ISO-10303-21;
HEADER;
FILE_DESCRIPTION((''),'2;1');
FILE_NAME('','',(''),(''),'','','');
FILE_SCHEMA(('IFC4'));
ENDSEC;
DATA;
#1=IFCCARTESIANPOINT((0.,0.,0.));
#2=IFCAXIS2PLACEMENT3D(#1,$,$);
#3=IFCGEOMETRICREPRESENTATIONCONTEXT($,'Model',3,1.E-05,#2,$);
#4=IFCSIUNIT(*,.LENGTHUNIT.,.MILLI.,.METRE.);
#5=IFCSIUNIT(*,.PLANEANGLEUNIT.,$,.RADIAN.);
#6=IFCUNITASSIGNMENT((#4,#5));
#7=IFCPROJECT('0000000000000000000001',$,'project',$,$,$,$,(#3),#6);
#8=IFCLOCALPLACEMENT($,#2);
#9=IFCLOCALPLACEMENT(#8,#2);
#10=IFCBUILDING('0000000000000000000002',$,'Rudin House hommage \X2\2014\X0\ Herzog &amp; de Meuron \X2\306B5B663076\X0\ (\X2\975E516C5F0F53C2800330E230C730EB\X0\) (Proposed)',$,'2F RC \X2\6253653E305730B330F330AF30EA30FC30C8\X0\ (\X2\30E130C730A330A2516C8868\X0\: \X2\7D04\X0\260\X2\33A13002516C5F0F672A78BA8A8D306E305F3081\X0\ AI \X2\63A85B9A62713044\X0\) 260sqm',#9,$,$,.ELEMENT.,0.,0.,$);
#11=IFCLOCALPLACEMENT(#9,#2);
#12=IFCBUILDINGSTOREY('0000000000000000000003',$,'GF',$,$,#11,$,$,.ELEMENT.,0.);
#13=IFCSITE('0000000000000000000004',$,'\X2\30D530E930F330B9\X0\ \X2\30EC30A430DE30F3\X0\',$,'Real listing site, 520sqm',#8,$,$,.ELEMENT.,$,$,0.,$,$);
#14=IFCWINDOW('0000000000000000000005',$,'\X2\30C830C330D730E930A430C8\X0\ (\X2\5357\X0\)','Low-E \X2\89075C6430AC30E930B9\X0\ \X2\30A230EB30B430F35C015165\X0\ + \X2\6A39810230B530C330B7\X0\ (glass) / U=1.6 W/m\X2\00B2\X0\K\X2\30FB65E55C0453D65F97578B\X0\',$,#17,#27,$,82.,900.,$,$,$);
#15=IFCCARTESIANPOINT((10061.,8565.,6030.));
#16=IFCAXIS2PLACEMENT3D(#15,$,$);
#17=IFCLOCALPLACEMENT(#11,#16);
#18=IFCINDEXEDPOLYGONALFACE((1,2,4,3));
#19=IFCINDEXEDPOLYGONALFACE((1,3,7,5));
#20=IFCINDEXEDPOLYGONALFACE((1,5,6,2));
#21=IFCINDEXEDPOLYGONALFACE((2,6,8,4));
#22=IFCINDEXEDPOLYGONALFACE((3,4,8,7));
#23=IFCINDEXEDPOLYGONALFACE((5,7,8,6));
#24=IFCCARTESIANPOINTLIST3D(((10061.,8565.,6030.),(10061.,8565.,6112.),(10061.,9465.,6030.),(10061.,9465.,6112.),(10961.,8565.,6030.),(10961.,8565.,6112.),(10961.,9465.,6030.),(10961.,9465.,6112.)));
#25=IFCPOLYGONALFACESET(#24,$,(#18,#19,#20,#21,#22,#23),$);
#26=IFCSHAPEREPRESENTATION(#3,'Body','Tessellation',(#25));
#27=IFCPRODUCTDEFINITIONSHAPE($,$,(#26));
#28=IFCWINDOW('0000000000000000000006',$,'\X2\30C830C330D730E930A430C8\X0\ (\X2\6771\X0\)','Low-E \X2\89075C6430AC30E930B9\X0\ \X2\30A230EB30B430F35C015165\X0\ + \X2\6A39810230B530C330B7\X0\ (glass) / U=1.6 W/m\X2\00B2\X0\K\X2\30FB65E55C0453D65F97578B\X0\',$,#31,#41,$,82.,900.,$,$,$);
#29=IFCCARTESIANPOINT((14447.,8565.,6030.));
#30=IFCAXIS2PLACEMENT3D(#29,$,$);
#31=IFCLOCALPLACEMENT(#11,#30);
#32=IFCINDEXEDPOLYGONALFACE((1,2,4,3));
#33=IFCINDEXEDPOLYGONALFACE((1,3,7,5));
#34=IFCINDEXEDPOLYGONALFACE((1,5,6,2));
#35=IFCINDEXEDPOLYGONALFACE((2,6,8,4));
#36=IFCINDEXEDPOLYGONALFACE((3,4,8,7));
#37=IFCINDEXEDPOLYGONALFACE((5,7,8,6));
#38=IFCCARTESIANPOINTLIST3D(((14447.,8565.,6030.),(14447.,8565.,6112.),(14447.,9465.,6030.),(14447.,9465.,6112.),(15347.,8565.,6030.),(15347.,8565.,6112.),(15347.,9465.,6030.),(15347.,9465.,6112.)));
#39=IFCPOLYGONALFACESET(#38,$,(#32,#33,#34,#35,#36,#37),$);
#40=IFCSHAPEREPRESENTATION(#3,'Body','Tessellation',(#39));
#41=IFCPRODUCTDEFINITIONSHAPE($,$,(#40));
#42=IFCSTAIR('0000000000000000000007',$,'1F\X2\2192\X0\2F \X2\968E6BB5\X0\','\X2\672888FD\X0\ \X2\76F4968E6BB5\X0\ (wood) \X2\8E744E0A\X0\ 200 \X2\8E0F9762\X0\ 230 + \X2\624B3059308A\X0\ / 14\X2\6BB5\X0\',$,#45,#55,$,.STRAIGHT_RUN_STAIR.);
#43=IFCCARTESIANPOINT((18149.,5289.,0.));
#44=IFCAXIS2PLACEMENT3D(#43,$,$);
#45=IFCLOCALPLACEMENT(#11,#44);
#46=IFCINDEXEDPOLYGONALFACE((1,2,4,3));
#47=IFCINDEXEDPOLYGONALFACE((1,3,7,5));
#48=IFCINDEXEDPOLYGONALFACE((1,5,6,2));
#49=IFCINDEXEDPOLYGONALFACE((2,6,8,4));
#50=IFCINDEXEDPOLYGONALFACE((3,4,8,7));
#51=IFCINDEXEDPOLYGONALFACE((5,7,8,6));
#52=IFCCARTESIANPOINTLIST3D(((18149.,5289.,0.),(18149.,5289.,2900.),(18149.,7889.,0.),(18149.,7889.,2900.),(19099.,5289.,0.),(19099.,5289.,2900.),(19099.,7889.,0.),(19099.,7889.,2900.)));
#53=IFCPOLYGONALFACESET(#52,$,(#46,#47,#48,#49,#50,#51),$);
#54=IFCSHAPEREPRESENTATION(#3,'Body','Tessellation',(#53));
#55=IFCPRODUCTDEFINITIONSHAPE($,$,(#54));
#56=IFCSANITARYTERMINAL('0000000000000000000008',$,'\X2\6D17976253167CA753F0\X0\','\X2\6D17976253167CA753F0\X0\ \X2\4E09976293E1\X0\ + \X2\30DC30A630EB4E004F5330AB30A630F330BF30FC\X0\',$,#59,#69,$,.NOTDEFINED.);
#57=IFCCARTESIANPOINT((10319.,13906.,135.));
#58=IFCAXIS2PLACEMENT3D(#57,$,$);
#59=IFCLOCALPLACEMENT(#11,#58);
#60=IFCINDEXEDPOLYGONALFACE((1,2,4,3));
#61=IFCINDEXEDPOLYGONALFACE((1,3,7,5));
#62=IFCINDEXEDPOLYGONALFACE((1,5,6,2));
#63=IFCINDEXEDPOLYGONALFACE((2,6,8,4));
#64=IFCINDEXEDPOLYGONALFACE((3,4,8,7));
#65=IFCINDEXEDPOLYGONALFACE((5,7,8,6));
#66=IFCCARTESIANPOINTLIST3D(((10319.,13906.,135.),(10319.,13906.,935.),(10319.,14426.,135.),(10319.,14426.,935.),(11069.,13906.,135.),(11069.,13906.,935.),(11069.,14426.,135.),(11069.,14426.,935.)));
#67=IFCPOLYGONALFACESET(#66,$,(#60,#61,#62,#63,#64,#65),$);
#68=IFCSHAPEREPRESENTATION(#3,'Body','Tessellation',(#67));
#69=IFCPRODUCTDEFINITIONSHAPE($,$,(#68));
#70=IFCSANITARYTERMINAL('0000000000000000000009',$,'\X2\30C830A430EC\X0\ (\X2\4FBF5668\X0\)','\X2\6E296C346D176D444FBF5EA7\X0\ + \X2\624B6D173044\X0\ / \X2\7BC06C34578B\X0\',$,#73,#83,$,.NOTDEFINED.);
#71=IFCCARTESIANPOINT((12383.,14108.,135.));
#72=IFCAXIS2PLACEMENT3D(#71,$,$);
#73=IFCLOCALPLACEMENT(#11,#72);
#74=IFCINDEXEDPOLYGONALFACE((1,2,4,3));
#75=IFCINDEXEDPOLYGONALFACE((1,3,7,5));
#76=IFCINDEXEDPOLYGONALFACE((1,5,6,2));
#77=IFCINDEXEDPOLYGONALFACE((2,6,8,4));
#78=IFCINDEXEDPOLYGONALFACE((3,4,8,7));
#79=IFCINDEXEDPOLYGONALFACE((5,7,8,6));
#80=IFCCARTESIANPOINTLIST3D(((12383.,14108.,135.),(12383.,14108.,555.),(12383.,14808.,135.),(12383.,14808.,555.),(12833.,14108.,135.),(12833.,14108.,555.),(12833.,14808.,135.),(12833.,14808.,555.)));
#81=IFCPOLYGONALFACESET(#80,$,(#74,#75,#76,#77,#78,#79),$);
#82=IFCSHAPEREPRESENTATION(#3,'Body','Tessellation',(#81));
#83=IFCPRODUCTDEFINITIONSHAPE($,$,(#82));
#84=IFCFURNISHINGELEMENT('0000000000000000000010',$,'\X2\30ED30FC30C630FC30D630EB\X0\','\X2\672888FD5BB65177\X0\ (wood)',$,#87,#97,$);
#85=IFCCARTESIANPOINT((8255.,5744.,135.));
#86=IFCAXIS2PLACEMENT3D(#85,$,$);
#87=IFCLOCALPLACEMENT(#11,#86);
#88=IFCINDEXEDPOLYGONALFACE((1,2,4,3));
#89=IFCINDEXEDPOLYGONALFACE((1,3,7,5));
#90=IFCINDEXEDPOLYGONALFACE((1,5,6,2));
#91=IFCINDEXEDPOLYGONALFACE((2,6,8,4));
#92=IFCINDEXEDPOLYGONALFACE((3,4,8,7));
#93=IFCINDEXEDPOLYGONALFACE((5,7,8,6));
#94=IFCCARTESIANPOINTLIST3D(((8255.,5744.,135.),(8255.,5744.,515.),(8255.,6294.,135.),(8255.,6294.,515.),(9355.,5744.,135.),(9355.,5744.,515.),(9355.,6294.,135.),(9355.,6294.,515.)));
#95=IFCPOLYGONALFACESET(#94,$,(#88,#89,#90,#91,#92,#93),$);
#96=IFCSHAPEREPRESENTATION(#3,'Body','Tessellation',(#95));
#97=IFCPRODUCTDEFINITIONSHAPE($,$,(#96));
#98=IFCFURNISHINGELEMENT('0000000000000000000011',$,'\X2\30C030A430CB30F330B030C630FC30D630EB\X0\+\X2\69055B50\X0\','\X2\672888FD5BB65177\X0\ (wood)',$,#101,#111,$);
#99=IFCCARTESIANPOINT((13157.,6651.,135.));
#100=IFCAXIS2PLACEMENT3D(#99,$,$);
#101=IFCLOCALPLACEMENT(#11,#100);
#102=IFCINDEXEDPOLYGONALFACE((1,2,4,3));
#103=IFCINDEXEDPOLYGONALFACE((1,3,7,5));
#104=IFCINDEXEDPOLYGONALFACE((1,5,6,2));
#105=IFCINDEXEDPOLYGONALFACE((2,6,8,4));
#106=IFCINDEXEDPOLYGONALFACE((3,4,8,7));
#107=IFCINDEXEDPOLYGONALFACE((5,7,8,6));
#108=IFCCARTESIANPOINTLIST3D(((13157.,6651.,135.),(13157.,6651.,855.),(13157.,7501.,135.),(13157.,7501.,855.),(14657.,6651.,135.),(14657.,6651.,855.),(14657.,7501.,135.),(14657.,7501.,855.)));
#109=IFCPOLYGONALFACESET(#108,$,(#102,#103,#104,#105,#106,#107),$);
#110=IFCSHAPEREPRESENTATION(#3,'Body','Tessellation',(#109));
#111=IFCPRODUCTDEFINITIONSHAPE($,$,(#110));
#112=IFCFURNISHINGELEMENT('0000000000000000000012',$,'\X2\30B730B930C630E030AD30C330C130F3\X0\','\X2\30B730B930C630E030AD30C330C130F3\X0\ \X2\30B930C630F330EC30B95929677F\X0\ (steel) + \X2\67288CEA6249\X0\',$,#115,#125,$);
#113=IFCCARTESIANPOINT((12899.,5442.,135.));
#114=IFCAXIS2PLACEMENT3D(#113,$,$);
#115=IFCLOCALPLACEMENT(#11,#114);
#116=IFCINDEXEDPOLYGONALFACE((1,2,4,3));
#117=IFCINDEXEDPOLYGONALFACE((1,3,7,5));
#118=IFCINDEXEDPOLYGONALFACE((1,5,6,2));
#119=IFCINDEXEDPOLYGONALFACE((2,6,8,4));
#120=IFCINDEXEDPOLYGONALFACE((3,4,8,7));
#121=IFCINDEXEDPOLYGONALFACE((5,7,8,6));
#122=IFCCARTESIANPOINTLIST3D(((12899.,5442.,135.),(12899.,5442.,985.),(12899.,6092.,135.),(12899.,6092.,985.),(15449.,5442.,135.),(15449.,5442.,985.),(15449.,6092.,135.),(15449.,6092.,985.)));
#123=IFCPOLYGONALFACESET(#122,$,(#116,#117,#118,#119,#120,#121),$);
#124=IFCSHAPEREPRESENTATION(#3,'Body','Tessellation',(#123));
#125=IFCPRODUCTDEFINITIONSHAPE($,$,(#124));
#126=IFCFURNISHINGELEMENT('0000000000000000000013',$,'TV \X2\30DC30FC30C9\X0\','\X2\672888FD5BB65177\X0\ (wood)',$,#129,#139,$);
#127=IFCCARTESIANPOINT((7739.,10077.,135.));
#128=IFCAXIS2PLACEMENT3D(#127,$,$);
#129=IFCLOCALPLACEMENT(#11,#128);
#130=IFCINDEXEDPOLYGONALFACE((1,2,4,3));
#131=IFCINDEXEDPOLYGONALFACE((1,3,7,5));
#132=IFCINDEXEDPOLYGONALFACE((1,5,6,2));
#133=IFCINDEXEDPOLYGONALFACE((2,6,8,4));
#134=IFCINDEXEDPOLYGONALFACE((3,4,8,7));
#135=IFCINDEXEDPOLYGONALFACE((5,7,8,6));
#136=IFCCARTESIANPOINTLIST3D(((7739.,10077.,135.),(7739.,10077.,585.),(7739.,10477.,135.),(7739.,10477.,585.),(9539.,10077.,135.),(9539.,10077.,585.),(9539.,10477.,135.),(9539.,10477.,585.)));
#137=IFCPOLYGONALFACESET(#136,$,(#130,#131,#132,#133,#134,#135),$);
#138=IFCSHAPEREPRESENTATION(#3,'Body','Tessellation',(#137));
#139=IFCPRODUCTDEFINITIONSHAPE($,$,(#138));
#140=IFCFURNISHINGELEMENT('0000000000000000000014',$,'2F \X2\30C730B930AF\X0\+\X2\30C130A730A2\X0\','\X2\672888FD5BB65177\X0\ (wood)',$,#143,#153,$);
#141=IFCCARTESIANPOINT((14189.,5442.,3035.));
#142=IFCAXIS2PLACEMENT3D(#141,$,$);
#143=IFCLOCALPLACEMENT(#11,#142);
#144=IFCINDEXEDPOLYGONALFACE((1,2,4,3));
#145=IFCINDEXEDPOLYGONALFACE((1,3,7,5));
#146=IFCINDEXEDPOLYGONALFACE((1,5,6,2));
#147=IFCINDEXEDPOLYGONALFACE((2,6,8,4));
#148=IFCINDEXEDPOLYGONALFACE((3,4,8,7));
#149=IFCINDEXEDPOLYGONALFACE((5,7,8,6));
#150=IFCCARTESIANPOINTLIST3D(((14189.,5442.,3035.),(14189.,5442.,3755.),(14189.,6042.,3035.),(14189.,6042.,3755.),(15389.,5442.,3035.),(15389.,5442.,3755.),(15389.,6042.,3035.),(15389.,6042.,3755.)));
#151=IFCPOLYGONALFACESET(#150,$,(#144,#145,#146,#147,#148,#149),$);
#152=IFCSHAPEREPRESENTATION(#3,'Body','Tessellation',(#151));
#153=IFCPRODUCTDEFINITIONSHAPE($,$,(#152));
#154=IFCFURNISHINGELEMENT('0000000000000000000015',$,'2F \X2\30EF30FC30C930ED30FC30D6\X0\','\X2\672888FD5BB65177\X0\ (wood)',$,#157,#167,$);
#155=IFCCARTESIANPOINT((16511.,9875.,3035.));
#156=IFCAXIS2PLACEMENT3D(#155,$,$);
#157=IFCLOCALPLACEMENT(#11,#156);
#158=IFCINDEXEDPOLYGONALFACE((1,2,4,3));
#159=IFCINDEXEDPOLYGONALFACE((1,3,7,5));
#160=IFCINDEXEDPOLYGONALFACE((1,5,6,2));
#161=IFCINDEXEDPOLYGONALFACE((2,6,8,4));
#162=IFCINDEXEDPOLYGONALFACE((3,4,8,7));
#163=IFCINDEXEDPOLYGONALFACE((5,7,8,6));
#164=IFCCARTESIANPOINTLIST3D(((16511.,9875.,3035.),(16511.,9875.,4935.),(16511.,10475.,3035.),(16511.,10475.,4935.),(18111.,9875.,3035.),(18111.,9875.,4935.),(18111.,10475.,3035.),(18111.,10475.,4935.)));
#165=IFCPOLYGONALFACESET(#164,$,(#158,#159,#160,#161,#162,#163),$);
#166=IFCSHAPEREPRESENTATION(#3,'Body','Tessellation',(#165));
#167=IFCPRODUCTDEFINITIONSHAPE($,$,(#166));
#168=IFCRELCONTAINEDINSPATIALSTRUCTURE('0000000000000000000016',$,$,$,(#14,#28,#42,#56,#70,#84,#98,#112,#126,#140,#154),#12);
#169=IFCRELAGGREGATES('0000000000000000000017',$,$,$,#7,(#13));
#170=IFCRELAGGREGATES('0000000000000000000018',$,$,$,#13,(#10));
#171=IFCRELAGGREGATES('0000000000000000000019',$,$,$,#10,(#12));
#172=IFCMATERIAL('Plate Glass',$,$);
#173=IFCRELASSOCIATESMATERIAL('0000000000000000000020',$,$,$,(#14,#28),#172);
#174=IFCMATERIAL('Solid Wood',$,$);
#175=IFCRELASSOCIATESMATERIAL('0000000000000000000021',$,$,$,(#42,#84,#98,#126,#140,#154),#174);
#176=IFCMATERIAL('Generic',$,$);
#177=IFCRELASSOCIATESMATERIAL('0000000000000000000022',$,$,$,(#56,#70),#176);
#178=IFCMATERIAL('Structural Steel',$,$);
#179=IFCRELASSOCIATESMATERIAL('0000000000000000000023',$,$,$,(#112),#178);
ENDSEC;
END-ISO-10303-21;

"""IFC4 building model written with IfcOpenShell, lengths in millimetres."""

from ifc_helpers import new_model, si_unit, frame, frame_2d, origin, place, context, project, spatial, rectangle, extrude, material, element, save


model = new_model("IFC4")

# Units and contexts
model_context = context("Model", 3, precision=1e-05, world=origin())
ifc_project = project(units=[si_unit("LENGTHUNIT", "METRE", prefix="MILLI"), si_unit("PLANEANGLEUNIT", "RADIAN")], contexts=[model_context])

# Site, building, storey
site_placement = place(None, origin())
site = spatial("IfcSite", under=ifc_project, at=site_placement, Name="フランス レイマン", ObjectType="Real listing site, 520sqm", CompositionType="ELEMENT", RefElevation=0.0)
building_placement = place(site_placement, origin())
building = spatial("IfcBuilding", under=site, at=building_placement, Name="Rudin House hommage — Herzog &amp; de Meuron に学ぶ (非公式参考モデル) (Proposed)", ObjectType="2F RC 打放しコンクリート (メディア公表: 約260㎡。公式未確認のため AI 推定扱い) 260sqm", CompositionType="ELEMENT", ElevationOfRefHeight=0.0, ElevationOfTerrain=0.0)
storey_placement = place(building_placement, origin())
storey = spatial("IfcBuildingStorey", under=building, at=storey_placement, Name="GF", CompositionType="ELEMENT", Elevation=0.0)

# Shared definitions
ifc_material_1 = material(Name="Solid Wood")

# Shared definitions
ifc_material_2 = material(Name="Plate Glass")

# Windows
window_1_placement = place(storey_placement, frame((10061.0, 8565.0, 6030.0)))
element("IfcWindow", 1, at=window_1_placement, inside=storey, material=ifc_material_2, Name="トップライト (南)", Description="Low-E 複層ガラス アルゴン封入 + 樹脂サッシ (glass) / U=1.6 W/m²K・日射取得型", OverallHeight=82.0, OverallWidth=900.0, context=model_context, shape_type="SweptSolid", body=[
    extrude(rectangle(XDim=900.0, YDim=900.0, at=frame_2d((450.0, 450.0))), frame((10061.0, 8565.0, 6030.0)), (0.0, 0.0, 1.0), 82.0),
])
window_2_placement = place(storey_placement, frame((14447.0, 8565.0, 6030.0)))
element("IfcWindow", 2, at=window_2_placement, inside=storey, material=ifc_material_2, Name="トップライト (東)", Description="Low-E 複層ガラス アルゴン封入 + 樹脂サッシ (glass) / U=1.6 W/m²K・日射取得型", OverallHeight=82.0, OverallWidth=900.0, context=model_context, shape_type="SweptSolid", body=[
    extrude(rectangle(XDim=900.0, YDim=900.0, at=frame_2d((450.0, 450.0))), frame((14447.0, 8565.0, 6030.0)), (0.0, 0.0, 1.0), 82.0),
])

# Stair
stair_placement = place(storey_placement, frame((18149.0, 5289.0, 0.0)))
element("IfcStair", 3, at=stair_placement, inside=storey, material=ifc_material_1, Name="1F→2F 階段", Description="木製 直階段 (wood) 蹴上 200 踏面 230 + 手すり / 14段", PredefinedType="STRAIGHT_RUN_STAIR", context=model_context, shape_type="SweptSolid", body=[
    extrude(rectangle(XDim=950.0, YDim=2600.0, at=frame_2d((475.0, 1300.0))), frame((18149.0, 5289.0, 0.0)), (0.0, 0.0, 1.0), 2900.0),
])

# Sanitary terminals
ifc_material_3 = material(Name="Generic")
sanitary_terminal_1_placement = place(storey_placement, frame((10319.0, 13906.0, 135.0)))
element("IfcSanitaryTerminal", 4, at=sanitary_terminal_1_placement, inside=storey, material=ifc_material_3, Name="洗面化粧台", Description="洗面化粧台 三面鏡 + ボウル一体カウンター", PredefinedType="NOTDEFINED", context=model_context, shape_type="SweptSolid", body=[
    extrude(rectangle(XDim=750.0, YDim=520.0, at=frame_2d((375.0, 260.0))), frame((10319.0, 13906.0, 135.0)), (0.0, 0.0, 1.0), 800.0),
])
sanitary_terminal_2_placement = place(storey_placement, frame((12383.0, 14108.0, 135.0)))
element("IfcSanitaryTerminal", 5, at=sanitary_terminal_2_placement, inside=storey, material=ifc_material_3, Name="トイレ (便器)", Description="温水洗浄便座 + 手洗い / 節水型", PredefinedType="NOTDEFINED", context=model_context, shape_type="SweptSolid", body=[
    extrude(rectangle(XDim=450.0, YDim=700.0, at=frame_2d((225.0, 350.0))), frame((12383.0, 14108.0, 135.0)), (0.0, 0.0, 1.0), 420.0),
])

# Furnishing elements
furnishing_1_placement = place(storey_placement, frame((8255.0, 5744.0, 135.0)))
element("IfcFurnishingElement", 6, at=furnishing_1_placement, inside=storey, material=ifc_material_1, Name="ローテーブル", Description="木製家具 (wood)", context=model_context, shape_type="SweptSolid", body=[
    extrude(rectangle(XDim=1100.0, YDim=550.0, at=frame_2d((550.0, 275.0))), frame((8255.0, 5744.0, 135.0)), (0.0, 0.0, 1.0), 380.0),
])
furnishing_2_placement = place(storey_placement, frame((13157.0, 6651.0, 135.0)))
element("IfcFurnishingElement", 7, at=furnishing_2_placement, inside=storey, material=ifc_material_1, Name="ダイニングテーブル+椅子", Description="木製家具 (wood)", context=model_context, shape_type="SweptSolid", body=[
    extrude(rectangle(XDim=1500.0, YDim=850.0, at=frame_2d((750.0, 425.0))), frame((13157.0, 6651.0, 135.0)), (0.0, 0.0, 1.0), 720.0),
])
ifc_material_4 = material(Name="Structural Steel")
furnishing_3_placement = place(storey_placement, frame((12899.0, 5442.0, 135.0)))
element("IfcFurnishingElement", 8, at=furnishing_3_placement, inside=storey, material=ifc_material_4, Name="システムキッチン", Description="システムキッチン ステンレス天板 (steel) + 木質扉", context=model_context, shape_type="SweptSolid", body=[
    extrude(rectangle(XDim=2550.0, YDim=650.0, at=frame_2d((1275.0, 325.0))), frame((12899.0, 5442.0, 135.0)), (0.0, 0.0, 1.0), 850.0),
])
furnishing_4_placement = place(storey_placement, frame((7739.0, 10077.0, 135.0)))
element("IfcFurnishingElement", 9, at=furnishing_4_placement, inside=storey, material=ifc_material_1, Name="TV ボード", Description="木製家具 (wood)", context=model_context, shape_type="SweptSolid", body=[
    extrude(rectangle(XDim=1800.0, YDim=400.0, at=frame_2d((900.0, 200.0))), frame((7739.0, 10077.0, 135.0)), (0.0, 0.0, 1.0), 450.0),
])
furnishing_5_placement = place(storey_placement, frame((14189.0, 5442.0, 3035.0)))
element("IfcFurnishingElement", 10, at=furnishing_5_placement, inside=storey, material=ifc_material_1, Name="2F デスク+チェア", Description="木製家具 (wood)", context=model_context, shape_type="SweptSolid", body=[
    extrude(rectangle(XDim=1200.0, YDim=600.0, at=frame_2d((600.0, 300.0))), frame((14189.0, 5442.0, 3035.0)), (0.0, 0.0, 1.0), 720.0),
])
furnishing_6_placement = place(storey_placement, frame((16511.0, 9875.0, 3035.0)))
element("IfcFurnishingElement", 11, at=furnishing_6_placement, inside=storey, material=ifc_material_1, Name="2F ワードローブ", Description="木製家具 (wood)", context=model_context, shape_type="SweptSolid", body=[
    extrude(rectangle(XDim=1600.0, YDim=600.0, at=frame_2d((800.0, 300.0))), frame((16511.0, 9875.0, 3035.0)), (0.0, 0.0, 1.0), 1900.0),
])

save(model, "model.ifc")
